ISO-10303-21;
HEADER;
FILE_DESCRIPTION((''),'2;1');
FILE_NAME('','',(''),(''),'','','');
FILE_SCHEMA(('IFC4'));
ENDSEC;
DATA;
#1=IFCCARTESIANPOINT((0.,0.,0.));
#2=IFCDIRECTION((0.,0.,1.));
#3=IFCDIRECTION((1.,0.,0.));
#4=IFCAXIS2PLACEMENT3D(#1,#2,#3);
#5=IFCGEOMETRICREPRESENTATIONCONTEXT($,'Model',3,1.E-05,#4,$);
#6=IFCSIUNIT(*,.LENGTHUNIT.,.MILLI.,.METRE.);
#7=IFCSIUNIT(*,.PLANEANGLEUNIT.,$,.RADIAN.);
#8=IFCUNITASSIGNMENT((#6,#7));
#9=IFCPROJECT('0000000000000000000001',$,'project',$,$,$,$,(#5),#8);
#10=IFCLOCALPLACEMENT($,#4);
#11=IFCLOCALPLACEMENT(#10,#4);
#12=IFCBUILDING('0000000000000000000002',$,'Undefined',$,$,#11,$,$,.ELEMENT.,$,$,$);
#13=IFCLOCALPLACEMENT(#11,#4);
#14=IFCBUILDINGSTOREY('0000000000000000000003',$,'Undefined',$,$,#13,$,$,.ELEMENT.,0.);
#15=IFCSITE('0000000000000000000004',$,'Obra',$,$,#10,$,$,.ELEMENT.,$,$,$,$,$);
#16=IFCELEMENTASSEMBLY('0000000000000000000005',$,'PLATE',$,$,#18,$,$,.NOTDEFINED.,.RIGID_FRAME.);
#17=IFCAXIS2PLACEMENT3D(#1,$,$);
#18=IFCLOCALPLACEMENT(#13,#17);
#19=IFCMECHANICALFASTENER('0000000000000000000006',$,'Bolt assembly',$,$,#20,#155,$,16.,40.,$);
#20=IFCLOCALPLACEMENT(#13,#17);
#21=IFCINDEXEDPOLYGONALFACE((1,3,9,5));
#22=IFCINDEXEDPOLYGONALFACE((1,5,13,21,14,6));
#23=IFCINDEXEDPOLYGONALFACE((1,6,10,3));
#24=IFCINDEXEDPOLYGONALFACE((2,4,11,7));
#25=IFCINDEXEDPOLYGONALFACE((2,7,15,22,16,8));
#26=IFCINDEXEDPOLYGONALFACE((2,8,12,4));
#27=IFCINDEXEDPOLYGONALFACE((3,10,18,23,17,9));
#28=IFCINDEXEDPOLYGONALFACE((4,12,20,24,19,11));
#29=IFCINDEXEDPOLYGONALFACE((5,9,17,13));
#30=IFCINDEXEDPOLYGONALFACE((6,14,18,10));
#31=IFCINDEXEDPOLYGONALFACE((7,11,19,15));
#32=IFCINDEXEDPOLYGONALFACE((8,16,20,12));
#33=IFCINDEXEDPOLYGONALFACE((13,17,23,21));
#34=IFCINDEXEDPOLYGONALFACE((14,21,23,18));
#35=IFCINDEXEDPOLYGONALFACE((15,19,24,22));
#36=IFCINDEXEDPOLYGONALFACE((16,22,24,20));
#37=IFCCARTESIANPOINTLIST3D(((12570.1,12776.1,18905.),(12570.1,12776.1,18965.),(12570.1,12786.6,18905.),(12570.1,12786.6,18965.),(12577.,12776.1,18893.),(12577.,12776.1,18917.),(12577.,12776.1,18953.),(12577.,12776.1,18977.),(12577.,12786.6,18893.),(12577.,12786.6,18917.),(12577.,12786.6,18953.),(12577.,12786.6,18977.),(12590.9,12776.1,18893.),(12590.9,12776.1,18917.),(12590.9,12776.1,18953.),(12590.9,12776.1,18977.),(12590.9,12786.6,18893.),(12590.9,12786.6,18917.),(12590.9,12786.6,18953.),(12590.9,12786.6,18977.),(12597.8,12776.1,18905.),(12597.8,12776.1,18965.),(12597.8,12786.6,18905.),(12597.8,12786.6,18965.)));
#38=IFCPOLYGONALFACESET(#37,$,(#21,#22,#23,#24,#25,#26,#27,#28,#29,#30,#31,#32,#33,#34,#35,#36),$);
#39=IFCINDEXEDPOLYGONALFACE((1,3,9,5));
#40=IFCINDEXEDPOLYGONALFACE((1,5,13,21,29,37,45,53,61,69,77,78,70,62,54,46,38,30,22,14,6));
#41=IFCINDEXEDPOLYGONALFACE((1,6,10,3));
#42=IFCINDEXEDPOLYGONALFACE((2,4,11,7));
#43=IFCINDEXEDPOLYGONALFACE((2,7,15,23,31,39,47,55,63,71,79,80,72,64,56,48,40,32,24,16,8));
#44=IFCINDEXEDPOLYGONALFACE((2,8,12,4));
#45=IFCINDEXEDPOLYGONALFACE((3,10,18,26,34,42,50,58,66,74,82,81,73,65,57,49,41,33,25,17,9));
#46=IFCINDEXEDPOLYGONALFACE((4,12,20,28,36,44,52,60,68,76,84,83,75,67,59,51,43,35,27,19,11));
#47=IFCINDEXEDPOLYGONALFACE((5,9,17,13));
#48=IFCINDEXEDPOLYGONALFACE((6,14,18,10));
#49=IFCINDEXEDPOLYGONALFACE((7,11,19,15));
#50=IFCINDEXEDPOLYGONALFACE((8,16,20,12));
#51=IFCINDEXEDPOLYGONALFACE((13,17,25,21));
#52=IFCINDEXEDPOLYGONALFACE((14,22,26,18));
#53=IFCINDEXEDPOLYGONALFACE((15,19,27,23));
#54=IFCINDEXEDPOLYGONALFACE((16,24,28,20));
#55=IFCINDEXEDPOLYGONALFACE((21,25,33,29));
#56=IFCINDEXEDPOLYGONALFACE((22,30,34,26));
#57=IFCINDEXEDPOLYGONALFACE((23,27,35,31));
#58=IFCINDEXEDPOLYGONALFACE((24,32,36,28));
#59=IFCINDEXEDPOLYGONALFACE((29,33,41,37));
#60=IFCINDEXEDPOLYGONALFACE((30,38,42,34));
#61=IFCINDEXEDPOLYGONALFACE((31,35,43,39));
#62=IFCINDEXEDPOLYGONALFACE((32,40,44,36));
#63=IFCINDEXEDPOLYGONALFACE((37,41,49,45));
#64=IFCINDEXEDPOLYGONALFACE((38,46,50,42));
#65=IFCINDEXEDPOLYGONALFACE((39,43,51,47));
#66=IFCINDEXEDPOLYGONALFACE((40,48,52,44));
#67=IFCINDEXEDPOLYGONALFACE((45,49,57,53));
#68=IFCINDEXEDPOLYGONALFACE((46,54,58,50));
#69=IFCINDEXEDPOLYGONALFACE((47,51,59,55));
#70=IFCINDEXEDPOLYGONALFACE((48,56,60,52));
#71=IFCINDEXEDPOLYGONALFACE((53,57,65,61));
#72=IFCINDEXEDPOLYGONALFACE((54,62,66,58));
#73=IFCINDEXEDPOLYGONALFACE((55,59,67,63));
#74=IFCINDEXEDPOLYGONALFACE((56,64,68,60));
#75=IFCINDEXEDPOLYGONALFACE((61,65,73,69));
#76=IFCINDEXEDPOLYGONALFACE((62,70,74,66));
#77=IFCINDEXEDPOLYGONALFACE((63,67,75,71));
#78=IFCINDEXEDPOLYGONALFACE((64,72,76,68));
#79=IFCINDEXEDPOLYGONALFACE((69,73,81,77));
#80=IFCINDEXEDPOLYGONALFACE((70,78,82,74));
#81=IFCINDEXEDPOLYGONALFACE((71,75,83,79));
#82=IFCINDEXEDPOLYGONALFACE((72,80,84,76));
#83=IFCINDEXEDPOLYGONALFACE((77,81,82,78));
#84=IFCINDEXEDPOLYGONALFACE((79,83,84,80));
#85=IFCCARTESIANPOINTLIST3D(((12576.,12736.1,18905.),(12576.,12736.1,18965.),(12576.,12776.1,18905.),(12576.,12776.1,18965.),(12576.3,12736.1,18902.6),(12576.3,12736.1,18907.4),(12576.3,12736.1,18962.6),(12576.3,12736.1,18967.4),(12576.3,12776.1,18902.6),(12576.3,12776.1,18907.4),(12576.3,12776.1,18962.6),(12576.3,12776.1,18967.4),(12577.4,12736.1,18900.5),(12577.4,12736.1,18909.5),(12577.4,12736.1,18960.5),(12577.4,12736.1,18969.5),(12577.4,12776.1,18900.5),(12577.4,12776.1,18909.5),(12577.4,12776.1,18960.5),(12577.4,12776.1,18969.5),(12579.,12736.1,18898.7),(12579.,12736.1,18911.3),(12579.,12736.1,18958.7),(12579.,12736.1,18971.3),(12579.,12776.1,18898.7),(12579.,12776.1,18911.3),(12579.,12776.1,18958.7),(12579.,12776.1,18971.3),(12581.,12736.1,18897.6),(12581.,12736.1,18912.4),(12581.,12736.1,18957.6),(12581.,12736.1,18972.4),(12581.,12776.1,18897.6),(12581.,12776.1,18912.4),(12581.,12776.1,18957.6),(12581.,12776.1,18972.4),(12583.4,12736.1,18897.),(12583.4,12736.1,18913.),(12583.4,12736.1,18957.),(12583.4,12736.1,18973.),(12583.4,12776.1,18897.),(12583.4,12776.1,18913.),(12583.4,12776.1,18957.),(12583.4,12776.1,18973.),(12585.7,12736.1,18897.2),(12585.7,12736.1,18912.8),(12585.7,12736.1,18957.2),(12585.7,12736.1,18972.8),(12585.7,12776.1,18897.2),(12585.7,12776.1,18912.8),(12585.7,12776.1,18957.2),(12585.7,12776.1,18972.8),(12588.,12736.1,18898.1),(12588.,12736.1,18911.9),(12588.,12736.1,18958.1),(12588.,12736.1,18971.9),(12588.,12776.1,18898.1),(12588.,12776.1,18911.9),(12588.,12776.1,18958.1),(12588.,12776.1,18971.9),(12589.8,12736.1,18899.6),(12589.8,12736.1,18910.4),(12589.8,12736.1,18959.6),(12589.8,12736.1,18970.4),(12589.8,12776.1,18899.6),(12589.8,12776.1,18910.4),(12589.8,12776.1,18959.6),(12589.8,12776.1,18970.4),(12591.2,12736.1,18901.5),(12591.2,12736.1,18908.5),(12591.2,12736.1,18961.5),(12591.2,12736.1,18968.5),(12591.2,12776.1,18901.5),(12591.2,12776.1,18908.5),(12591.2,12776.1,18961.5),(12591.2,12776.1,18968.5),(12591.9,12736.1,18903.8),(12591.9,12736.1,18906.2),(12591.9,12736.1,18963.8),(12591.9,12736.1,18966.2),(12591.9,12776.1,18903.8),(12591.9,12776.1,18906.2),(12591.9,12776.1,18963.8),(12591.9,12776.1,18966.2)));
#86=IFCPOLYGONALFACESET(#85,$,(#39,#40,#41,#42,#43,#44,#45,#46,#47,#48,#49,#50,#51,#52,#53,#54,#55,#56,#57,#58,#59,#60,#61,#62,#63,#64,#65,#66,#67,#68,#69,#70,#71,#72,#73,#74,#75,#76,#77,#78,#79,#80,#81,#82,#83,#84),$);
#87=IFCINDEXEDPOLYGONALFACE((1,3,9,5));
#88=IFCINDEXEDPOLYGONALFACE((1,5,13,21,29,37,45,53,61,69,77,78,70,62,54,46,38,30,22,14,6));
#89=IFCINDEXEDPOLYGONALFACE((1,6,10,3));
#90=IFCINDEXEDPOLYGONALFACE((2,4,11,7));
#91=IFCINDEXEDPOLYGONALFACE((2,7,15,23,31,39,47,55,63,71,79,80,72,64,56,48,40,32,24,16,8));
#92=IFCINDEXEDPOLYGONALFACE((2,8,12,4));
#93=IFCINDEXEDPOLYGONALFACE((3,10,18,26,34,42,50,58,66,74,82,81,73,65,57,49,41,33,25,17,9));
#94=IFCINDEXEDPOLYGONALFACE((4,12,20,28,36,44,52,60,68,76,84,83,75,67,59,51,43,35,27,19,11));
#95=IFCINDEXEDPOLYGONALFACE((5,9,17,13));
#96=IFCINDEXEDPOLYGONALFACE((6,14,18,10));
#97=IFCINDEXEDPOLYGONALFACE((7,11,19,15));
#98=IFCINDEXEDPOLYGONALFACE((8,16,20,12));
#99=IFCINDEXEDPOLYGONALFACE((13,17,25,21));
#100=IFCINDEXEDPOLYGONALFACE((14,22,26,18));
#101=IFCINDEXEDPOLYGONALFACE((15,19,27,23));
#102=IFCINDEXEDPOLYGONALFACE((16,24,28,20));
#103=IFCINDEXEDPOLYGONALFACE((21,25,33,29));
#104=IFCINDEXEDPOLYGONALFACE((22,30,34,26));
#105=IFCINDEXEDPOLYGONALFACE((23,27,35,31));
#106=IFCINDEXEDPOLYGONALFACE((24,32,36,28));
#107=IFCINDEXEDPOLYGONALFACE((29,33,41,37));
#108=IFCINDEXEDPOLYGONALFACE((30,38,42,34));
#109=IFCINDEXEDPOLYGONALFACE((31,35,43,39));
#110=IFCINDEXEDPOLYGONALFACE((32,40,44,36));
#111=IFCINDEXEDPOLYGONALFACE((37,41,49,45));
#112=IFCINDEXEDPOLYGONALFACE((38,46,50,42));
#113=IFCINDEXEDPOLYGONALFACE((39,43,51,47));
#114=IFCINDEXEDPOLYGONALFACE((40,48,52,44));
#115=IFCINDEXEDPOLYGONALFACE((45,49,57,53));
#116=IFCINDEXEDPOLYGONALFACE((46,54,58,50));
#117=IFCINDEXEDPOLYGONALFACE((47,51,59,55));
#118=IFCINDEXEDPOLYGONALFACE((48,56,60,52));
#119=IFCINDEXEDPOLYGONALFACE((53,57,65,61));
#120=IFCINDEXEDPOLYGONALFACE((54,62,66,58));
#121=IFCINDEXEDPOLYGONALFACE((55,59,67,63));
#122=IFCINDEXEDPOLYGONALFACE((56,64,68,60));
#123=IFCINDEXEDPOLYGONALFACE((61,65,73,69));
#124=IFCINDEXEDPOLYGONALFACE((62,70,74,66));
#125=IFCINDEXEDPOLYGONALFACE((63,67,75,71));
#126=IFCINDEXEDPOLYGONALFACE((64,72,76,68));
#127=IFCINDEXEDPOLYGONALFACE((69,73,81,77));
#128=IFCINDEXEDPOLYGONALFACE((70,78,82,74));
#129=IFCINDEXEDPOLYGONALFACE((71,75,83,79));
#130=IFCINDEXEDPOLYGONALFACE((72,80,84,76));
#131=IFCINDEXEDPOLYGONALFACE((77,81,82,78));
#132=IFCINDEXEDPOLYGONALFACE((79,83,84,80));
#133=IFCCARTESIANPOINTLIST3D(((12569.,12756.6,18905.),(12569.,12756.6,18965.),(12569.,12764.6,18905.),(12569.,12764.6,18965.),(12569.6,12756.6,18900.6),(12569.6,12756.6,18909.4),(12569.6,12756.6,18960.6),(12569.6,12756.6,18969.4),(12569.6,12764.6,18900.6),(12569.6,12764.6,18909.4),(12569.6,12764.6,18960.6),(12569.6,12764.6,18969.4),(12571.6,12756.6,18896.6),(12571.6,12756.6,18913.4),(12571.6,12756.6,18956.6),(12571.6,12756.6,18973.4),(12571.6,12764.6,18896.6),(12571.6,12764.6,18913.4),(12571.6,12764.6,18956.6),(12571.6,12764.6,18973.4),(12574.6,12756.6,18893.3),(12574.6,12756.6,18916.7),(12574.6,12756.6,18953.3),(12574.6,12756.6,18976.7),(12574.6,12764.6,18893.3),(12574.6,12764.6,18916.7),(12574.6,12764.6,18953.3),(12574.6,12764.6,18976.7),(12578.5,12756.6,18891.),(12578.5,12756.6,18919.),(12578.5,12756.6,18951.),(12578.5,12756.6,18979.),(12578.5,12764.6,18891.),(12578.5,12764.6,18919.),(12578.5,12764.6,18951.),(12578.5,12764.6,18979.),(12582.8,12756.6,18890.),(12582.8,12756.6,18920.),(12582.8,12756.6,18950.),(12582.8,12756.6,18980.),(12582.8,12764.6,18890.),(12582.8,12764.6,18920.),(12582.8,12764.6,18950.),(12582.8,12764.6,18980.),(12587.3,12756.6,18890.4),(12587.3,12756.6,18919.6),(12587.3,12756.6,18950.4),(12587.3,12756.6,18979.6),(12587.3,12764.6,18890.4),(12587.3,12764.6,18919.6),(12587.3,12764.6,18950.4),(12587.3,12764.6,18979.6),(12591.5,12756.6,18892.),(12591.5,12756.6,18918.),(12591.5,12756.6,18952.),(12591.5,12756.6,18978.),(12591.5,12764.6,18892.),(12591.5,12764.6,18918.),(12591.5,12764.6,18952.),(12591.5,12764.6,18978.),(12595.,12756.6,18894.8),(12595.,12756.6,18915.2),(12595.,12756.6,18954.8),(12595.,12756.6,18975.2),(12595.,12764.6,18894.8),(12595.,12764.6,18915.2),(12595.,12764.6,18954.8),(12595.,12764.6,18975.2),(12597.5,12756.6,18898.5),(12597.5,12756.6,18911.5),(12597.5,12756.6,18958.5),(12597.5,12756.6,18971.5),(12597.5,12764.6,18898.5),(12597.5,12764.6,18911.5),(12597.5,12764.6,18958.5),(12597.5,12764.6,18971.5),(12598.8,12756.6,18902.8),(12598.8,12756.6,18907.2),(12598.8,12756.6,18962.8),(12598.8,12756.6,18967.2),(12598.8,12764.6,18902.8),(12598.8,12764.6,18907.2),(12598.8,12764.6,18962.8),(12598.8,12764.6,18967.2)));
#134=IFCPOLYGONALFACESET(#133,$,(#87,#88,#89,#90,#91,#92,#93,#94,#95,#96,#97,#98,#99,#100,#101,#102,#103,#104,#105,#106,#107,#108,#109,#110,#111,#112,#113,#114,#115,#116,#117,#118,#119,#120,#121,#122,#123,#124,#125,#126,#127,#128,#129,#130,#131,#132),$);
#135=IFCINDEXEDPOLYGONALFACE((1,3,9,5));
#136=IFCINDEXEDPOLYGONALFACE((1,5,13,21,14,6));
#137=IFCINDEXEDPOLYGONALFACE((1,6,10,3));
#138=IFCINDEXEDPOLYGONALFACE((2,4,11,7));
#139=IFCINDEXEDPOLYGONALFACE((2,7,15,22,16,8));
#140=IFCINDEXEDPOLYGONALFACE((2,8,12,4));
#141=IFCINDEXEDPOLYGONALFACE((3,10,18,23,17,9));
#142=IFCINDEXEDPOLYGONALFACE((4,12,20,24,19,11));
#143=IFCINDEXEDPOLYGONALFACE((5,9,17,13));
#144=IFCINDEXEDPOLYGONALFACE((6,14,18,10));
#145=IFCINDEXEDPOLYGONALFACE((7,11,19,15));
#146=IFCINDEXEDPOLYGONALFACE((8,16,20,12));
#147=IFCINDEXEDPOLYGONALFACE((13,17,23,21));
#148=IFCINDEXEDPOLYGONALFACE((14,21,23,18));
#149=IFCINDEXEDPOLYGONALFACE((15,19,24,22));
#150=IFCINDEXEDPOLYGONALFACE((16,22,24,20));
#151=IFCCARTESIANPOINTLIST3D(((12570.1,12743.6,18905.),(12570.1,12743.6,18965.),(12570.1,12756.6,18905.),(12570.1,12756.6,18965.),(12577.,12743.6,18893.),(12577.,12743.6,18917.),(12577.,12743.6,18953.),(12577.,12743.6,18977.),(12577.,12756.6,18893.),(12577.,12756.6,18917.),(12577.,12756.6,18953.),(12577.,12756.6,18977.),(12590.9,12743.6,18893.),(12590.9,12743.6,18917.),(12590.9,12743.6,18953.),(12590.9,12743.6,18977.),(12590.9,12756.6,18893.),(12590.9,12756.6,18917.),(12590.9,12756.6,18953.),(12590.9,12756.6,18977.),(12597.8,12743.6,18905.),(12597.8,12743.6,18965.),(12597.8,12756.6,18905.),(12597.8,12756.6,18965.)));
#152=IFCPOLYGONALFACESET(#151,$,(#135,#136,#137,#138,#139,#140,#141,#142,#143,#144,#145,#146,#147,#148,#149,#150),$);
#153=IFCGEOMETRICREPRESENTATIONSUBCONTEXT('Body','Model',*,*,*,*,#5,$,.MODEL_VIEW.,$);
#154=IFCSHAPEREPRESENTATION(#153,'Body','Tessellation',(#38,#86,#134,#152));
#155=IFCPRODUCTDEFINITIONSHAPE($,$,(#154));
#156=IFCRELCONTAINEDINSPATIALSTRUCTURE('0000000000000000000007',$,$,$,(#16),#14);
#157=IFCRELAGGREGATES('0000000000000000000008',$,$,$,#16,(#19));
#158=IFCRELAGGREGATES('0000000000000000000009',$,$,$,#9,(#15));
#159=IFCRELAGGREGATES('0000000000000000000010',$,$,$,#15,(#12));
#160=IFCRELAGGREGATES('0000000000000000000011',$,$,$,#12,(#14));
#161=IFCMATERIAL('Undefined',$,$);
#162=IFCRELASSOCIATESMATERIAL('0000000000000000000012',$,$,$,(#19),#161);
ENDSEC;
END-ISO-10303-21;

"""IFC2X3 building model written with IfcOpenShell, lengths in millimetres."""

from ifc_helpers import new_model, si_unit, frame, origin_with_axes, origin_2d_with_axis, place, context, subcontext, project, spatial, polyline, circle, outline, extrude, source, transform, mapped, material, element, aggregate, save


model = new_model("IFC2X3")

# Units and contexts
model_context = context("Model", 3, precision=1e-05, world=origin_with_axes())
body_context = subcontext(model_context, "Body", "Model", "MODEL_VIEW")
ifc_project = project(units=[si_unit("LENGTHUNIT", "METRE", prefix="MILLI"), si_unit("PLANEANGLEUNIT", "RADIAN")], contexts=[model_context])

# Site, building, storey
site_placement = place(None, origin_with_axes())
site = spatial("IfcSite", under=ifc_project, at=site_placement, Name="Obra", CompositionType="ELEMENT")
building_placement = place(site_placement, origin_with_axes())
building = spatial("IfcBuilding", under=site, at=building_placement, Name="Undefined", CompositionType="ELEMENT")
storey_placement = place(building_placement, origin_with_axes())
storey = spatial("IfcBuildingStorey", under=building, at=storey_placement, Name="Undefined", CompositionType="ELEMENT", Elevation=0.0)

# Element assembly
assembly_1_placement = place(storey_placement, origin_with_axes())
assembly_1 = element("IfcElementAssembly", 1, at=assembly_1_placement, inside=storey, Name="PLATE", AssemblyPlace="NOTDEFINED", PredefinedType="RIGID_FRAME")

# Mechanical fastener
ifc_material_1 = material(Name="Undefined")
shared_shape_1 = source(origin_with_axes(), body_context, "Body", "SweptSolid", [
    extrude(outline(polyline([(13.9, 0.0), (6.9, 12.0), (-6.9, 12.0), (-13.9, 0.0), (-6.9, -12.0), (6.9, -12.0), (13.9, 0.0)])), frame((0.0, -16.6, 0.0), z_axis=(0.0, 1.0, 0.0), x_axis=(1.0, 0.0, 0.0)), (0.0, 0.0, 1.0), 10.6),
    extrude(circle(Radius=8.0, at=origin_2d_with_axis()), frame((0.0, -6.0, 0.0), z_axis=(0.0, 1.0, 0.0), x_axis=(1.0, 0.0, 0.0)), (0.0, 0.0, 1.0), 40.0),
    extrude(circle(Radius=15.0, at=origin_2d_with_axis()), frame((0.0, 5.5, 0.0), z_axis=(0.0, 1.0, 0.0), x_axis=(1.0, 0.0, 0.0)), (0.0, 0.0, 1.0), 8.0),
    extrude(outline(polyline([(13.9, 0.0), (6.9, 12.0), (-6.9, 12.0), (-13.9, 0.0), (-6.9, -12.0), (6.9, -12.0), (13.9, 0.0)])), frame((0.0, 13.5, 0.0), z_axis=(0.0, 1.0, 0.0), x_axis=(1.0, 0.0, 0.0)), (0.0, 0.0, 1.0), 13.0),
])
mechanical_fastener_1_placement = place(assembly_1_placement, frame((12584.0, 12770.1, 18935.0), z_axis=(0.0, 0.0, 1.0), x_axis=(-1.0, 0.0, 0.0)))
mechanical_fastener_1 = element("IfcMechanicalFastener", 2, at=mechanical_fastener_1_placement, material=ifc_material_1, Name="Bolt assembly", NominalDiameter=16.0, NominalLength=40.0, context=body_context, shape_type="MappedRepresentation", body=[
    mapped(shared_shape_1, transform((0.0, 0.0, -30.0))),
    mapped(shared_shape_1, transform((0.0, 0.0, 30.0))),
])
aggregate(assembly_1, [mechanical_fastener_1])

save(model, "model.ifc")
